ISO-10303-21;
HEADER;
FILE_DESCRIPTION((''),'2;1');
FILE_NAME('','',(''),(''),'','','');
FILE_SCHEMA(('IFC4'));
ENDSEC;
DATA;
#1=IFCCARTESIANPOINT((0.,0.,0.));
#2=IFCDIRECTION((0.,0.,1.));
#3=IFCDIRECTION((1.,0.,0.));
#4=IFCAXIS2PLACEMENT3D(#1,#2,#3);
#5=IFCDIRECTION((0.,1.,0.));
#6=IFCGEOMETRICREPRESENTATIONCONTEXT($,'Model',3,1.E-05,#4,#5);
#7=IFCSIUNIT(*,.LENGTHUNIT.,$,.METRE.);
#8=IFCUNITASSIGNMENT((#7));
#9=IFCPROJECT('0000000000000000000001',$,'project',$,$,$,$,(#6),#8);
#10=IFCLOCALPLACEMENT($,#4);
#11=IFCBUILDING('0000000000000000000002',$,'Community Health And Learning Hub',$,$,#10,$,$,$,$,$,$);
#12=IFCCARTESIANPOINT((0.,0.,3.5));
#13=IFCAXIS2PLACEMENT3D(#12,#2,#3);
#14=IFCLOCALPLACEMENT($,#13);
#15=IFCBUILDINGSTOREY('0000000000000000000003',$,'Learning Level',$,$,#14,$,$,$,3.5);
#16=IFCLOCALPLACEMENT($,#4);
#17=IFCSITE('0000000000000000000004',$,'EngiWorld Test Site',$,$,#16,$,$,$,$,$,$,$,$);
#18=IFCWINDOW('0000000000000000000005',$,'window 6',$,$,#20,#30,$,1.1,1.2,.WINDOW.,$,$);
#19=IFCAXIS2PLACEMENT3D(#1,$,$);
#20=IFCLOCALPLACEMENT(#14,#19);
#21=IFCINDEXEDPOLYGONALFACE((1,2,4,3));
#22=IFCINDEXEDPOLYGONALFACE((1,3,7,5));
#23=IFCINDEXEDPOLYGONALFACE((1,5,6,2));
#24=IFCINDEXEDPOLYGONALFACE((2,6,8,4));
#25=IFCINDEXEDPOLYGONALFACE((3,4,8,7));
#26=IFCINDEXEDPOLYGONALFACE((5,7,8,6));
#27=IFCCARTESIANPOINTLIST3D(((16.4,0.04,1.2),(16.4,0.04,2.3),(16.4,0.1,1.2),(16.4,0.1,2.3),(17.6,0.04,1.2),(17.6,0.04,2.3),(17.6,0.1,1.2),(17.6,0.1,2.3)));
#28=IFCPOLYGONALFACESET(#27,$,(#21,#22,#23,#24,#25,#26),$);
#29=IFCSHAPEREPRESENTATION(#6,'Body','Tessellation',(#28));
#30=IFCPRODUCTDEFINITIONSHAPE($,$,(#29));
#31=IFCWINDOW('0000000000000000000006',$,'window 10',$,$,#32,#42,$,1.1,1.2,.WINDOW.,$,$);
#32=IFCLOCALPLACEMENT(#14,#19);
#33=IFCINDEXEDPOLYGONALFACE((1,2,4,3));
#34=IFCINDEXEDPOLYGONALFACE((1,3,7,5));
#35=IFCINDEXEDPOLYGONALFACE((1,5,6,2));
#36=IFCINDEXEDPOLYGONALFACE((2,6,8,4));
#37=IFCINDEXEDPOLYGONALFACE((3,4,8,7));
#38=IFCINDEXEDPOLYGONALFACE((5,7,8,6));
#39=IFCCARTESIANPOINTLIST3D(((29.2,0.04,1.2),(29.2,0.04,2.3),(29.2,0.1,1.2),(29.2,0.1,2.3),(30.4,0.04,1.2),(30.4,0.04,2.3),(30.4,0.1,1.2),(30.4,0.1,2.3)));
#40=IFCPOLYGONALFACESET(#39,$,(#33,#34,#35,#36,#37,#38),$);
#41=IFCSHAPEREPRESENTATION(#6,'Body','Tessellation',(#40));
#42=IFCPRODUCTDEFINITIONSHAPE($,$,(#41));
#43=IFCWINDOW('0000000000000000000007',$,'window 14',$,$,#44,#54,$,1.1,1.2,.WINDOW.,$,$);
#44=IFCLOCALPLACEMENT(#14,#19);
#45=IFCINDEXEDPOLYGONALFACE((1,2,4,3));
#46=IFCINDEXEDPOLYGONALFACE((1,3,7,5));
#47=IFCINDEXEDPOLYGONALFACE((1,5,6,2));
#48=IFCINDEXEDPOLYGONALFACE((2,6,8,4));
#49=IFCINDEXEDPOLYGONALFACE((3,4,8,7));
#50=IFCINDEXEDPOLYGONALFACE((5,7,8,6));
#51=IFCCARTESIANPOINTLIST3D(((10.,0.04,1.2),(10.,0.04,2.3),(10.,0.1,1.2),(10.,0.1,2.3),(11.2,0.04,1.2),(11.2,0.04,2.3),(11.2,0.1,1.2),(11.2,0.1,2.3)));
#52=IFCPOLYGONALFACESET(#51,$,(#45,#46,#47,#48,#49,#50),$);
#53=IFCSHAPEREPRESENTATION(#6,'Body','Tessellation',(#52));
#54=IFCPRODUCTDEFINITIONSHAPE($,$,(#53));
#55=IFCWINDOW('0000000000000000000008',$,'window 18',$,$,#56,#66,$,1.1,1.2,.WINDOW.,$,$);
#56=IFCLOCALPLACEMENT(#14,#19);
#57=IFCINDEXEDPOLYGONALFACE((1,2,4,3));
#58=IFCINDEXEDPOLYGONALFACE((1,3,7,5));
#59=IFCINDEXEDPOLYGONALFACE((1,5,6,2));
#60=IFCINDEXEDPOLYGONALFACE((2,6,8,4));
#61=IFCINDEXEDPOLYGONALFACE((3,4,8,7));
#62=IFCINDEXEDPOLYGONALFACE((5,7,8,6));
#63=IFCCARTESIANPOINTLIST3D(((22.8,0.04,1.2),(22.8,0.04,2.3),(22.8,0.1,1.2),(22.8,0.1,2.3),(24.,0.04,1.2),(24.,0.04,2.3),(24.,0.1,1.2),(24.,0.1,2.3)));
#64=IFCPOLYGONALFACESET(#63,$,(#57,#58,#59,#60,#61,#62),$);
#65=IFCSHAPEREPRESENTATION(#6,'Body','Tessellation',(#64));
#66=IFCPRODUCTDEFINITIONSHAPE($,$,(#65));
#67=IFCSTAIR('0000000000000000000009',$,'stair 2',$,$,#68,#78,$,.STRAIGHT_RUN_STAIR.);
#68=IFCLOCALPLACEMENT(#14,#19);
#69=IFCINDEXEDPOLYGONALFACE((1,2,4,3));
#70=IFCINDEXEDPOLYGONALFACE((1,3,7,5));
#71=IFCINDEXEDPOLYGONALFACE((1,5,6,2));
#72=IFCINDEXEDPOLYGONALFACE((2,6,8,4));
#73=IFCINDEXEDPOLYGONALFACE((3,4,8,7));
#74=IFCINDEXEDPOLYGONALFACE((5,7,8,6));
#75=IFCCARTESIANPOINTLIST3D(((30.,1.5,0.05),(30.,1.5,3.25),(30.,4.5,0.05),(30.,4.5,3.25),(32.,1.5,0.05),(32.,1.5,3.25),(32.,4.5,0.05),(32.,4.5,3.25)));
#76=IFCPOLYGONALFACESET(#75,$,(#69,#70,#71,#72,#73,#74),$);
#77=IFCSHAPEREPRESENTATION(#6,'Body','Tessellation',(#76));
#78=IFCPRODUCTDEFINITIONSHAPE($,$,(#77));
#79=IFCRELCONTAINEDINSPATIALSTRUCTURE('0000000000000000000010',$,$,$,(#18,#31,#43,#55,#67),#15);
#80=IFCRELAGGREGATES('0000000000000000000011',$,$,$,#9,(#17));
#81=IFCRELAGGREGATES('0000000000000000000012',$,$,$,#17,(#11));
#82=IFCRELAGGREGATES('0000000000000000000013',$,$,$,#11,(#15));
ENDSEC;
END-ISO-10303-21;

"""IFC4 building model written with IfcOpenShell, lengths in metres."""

from ifc_helpers import new_model, si_unit, direction, frame, origin_with_axes, origin_2d_with_axis, place, context, project, spatial, rectangle, extrude, element, save


model = new_model("IFC4")

# Units and contexts
model_context = context("Model", 3, precision=1e-05, world=origin_with_axes(), true_north=direction((0.0, 1.0, 0.0)))
ifc_project = project(units=[si_unit("LENGTHUNIT", "METRE")], contexts=[model_context])

# Site, building, storey
site_placement = place(None, origin_with_axes())
site = spatial("IfcSite", under=ifc_project, at=site_placement, Name="EngiWorld Test Site")
building_placement = place(None, origin_with_axes())
building = spatial("IfcBuilding", under=site, at=building_placement, Name="Community Health And Learning Hub")
storey_placement = place(None, frame((0.0, 0.0, 3.5), z_axis=(0.0, 0.0, 1.0), x_axis=(1.0, 0.0, 0.0)))
storey = spatial("IfcBuildingStorey", under=building, at=storey_placement, Name="Learning Level", Elevation=3.5)

# Windows
for number, where, z_axis, x_axis, name in (
    (1, (17.0, 0.07, 4.7), (0.0, 0.0, 1.0), (1.0, 0.0, 0.0), "window 6"),
    (2, (29.8, 0.07, 4.7), (0.0, 0.0, 1.0), (1.0, 0.0, 0.0), "window 10"),
    (3, (10.6, 0.07, 4.7), (0.0, 0.0, 1.0), (1.0, 0.0, 0.0), "window 14"),
    (4, (23.4, 0.07, 4.7), (0.0, 0.0, 1.0), (1.0, 0.0, 0.0), "window 18"),
):
    element("IfcWindow", number, at=place(None, frame(where, z_axis=z_axis, x_axis=x_axis)), inside=storey, Name=name, OverallHeight=1.1, OverallWidth=1.2, PredefinedType="WINDOW", context=model_context, shape_type="SweptSolid", body=[
        extrude(rectangle(XDim=1.2, YDim=0.06, at=origin_2d_with_axis()), origin_with_axes(), (0.0, 0.0, 1.0), 1.1),
    ])

# Stair
stair_placement = place(None, frame((31.0, 3.0, 3.55), z_axis=(0.0, 0.0, 1.0), x_axis=(1.0, 0.0, 0.0)))
element("IfcStair", 5, at=stair_placement, inside=storey, Name="stair 2", PredefinedType="STRAIGHT_RUN_STAIR", context=model_context, shape_type="SweptSolid", body=[
    extrude(rectangle(XDim=2.0, YDim=3.0, at=origin_2d_with_axis()), origin_with_axes(), (0.0, 0.0, 1.0), 3.2),
])

save(model, "model.ifc")
